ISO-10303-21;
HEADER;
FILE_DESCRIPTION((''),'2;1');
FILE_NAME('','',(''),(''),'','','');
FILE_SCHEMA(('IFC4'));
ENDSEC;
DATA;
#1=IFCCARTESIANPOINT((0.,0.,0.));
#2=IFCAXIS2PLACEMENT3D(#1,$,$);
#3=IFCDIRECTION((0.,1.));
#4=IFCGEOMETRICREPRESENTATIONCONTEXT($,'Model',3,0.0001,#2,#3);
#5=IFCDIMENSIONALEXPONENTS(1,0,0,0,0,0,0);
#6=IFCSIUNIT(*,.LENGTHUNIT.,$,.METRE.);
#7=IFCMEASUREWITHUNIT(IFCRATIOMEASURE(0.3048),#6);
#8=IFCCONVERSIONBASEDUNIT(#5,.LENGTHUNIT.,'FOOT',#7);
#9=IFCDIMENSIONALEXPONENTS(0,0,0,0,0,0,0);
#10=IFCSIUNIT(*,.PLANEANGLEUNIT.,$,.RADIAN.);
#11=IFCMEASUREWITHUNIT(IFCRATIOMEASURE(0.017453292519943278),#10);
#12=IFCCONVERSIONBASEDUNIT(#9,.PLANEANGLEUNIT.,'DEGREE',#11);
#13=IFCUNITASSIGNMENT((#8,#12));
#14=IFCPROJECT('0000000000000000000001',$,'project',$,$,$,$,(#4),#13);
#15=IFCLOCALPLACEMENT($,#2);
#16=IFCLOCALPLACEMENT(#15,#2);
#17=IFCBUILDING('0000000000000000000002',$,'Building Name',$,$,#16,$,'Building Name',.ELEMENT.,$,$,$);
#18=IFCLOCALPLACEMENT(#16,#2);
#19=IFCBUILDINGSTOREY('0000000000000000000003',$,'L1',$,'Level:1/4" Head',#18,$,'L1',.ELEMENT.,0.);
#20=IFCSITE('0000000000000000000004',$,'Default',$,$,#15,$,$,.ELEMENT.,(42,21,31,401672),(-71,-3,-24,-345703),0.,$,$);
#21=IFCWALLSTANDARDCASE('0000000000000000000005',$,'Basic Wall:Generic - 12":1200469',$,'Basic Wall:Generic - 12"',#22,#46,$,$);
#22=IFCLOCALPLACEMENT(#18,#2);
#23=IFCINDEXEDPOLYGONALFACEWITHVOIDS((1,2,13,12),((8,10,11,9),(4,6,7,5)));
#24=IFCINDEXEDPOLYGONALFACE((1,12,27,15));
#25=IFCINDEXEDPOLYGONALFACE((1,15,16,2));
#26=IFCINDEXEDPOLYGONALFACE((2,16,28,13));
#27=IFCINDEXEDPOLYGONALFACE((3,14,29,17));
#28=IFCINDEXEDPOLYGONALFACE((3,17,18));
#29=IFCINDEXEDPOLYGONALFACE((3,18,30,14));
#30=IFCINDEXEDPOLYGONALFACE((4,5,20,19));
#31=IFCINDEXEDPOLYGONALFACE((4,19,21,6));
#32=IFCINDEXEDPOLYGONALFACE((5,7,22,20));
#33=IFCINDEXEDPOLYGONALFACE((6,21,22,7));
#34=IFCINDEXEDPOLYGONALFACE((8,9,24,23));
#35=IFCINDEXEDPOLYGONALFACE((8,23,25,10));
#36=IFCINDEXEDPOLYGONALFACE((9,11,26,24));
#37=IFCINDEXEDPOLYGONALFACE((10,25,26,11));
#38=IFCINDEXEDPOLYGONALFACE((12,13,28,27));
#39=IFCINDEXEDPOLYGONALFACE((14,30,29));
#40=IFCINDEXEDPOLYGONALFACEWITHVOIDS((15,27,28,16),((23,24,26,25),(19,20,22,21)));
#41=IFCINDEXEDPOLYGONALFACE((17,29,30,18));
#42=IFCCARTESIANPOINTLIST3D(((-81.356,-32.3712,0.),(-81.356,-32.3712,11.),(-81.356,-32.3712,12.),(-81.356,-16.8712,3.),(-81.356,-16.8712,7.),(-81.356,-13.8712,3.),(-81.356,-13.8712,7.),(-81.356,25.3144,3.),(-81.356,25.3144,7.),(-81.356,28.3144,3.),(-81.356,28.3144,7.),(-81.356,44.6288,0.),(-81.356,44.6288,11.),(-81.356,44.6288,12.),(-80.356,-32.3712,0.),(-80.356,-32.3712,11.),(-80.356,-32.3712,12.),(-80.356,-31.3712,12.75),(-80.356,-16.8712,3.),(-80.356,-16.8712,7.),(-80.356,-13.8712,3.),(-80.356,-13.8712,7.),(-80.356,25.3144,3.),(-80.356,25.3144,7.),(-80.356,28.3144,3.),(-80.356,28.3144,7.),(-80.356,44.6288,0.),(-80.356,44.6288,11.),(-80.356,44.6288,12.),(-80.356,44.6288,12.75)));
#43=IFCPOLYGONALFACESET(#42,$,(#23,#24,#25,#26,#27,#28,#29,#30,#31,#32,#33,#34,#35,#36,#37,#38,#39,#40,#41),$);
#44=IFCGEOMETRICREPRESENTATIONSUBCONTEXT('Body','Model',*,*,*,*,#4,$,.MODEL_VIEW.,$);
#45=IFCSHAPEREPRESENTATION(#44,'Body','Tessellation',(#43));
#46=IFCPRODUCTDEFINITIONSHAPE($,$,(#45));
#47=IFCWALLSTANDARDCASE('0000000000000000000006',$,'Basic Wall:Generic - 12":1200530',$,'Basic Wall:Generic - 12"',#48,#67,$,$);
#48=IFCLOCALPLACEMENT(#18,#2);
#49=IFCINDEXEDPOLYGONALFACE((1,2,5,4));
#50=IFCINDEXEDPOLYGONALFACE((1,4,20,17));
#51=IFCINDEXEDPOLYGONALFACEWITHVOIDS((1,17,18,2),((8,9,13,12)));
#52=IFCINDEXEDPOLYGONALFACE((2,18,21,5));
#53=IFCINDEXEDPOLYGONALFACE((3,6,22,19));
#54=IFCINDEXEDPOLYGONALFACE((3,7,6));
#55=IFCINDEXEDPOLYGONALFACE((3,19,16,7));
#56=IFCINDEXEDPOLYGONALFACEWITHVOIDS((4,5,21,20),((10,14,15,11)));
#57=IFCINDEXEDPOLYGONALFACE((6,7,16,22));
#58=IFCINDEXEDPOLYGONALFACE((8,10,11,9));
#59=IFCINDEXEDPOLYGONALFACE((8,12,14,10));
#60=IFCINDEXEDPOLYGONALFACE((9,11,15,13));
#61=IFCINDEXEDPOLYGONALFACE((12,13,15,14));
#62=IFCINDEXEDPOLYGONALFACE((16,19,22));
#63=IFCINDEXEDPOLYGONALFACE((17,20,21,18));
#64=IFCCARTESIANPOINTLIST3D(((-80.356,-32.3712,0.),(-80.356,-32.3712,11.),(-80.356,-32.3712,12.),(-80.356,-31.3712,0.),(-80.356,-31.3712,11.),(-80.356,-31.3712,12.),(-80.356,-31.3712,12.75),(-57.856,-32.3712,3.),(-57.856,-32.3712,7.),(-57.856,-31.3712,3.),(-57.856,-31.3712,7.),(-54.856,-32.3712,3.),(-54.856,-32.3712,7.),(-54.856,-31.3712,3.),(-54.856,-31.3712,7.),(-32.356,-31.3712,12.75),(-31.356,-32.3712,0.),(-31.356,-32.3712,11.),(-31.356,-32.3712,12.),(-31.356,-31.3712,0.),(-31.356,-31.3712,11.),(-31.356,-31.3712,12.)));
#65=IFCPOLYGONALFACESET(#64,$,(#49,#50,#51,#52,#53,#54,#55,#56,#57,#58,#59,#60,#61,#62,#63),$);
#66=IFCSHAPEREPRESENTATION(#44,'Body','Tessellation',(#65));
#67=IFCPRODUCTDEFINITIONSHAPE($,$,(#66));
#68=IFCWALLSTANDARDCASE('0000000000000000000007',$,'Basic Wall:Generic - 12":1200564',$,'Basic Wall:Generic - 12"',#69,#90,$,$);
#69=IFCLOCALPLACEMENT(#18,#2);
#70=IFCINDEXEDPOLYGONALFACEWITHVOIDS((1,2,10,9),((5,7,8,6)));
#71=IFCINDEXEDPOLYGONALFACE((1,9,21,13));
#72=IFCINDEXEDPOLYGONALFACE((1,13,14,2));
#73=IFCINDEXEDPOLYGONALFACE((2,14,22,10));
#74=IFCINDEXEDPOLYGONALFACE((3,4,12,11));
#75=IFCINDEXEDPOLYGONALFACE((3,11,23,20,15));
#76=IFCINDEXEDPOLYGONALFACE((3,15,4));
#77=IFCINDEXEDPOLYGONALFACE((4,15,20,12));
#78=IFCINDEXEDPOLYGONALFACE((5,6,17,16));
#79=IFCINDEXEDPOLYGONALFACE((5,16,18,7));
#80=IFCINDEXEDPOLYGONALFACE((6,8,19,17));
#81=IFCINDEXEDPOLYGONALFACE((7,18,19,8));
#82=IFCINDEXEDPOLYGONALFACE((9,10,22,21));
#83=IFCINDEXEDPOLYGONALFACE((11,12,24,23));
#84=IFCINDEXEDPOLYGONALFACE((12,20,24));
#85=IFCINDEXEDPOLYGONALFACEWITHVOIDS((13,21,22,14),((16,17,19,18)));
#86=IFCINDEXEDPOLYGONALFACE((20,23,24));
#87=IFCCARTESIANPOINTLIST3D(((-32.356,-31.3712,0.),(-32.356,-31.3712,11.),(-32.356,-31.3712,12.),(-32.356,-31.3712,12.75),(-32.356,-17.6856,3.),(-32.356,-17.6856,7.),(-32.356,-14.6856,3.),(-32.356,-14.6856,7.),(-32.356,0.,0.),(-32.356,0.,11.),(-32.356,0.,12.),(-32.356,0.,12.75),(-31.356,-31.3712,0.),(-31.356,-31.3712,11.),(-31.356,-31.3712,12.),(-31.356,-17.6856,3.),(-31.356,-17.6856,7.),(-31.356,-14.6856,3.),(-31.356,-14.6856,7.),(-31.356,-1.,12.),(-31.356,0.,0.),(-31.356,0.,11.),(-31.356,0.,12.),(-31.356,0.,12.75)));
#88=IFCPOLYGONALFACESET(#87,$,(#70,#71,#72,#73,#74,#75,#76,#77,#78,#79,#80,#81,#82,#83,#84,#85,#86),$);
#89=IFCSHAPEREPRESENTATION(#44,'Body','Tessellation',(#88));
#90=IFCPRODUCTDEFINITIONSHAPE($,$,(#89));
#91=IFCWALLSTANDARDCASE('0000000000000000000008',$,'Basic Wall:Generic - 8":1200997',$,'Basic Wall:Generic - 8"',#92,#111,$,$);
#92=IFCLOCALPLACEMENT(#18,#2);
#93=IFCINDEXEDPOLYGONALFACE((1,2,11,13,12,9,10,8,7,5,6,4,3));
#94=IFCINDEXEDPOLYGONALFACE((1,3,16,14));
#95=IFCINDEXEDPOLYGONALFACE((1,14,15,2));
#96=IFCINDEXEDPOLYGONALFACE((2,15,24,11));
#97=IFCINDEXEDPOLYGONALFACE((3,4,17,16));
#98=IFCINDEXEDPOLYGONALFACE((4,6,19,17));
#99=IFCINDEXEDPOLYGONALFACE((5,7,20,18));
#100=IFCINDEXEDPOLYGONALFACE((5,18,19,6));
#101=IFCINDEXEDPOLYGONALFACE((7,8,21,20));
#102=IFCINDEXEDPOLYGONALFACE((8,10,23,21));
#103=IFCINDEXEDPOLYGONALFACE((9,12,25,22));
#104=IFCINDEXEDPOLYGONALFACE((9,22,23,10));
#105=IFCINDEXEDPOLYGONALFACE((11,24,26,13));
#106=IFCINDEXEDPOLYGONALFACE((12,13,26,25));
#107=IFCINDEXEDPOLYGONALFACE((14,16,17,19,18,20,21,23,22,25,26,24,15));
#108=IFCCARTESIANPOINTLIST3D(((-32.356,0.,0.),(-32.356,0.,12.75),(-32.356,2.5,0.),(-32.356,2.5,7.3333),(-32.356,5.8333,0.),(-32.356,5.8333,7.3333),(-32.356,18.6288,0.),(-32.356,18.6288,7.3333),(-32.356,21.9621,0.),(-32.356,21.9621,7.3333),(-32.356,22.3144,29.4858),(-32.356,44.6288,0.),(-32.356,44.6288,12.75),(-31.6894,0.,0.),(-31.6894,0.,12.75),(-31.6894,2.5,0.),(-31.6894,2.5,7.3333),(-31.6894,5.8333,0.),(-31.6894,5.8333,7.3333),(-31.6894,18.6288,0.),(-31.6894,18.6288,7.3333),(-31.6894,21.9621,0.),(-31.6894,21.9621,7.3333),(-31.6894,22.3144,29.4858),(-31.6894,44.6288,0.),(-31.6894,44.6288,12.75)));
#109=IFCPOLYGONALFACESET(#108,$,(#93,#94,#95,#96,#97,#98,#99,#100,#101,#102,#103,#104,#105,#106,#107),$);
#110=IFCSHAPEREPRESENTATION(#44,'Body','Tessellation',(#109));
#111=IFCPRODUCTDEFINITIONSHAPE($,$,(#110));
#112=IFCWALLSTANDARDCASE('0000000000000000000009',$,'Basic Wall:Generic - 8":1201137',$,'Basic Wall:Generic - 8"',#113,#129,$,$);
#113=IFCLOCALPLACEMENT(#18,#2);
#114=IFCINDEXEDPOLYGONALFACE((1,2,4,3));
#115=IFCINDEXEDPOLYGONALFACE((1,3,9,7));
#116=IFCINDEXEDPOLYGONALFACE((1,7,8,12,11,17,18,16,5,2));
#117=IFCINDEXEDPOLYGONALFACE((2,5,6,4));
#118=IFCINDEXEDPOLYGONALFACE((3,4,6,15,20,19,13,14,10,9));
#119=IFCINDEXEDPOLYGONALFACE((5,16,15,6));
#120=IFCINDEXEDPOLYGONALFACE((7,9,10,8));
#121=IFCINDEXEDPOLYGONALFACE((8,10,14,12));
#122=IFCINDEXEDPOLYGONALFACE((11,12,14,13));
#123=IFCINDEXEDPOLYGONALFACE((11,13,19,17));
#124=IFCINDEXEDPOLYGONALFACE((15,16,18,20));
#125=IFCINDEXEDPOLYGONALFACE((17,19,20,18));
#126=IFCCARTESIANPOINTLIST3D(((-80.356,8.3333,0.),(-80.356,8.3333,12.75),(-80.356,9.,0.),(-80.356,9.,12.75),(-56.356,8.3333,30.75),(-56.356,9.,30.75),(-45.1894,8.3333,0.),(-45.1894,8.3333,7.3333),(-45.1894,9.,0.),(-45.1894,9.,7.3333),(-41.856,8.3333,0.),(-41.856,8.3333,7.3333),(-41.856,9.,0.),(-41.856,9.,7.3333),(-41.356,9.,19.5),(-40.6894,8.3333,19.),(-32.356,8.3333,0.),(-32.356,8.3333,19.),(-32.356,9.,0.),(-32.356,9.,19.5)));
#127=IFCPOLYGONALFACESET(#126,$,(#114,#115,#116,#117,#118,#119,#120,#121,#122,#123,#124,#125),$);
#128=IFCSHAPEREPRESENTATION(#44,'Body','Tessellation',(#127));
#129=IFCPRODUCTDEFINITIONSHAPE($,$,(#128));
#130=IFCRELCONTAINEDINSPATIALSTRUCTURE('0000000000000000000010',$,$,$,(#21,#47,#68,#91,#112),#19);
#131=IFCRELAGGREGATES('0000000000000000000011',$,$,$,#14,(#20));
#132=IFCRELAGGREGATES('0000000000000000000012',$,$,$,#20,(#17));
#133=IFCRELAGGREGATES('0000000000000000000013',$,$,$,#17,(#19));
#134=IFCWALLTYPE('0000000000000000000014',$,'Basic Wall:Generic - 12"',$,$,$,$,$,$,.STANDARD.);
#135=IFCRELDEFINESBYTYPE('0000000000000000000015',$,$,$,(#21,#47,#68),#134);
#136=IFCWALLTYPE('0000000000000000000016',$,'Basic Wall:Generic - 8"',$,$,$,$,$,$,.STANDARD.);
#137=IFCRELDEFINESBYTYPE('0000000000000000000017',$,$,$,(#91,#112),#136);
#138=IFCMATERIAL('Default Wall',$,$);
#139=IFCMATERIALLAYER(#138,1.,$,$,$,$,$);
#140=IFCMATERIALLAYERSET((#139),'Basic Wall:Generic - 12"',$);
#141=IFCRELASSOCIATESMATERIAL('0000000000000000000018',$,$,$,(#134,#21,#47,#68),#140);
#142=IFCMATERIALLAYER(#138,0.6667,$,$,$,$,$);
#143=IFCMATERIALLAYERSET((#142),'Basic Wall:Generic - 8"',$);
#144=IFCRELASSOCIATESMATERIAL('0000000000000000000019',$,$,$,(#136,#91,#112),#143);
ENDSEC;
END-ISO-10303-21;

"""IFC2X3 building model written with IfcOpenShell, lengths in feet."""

from ifc_helpers import new_model, entity, si_unit, converted_unit, direction, frame, frame_2d, origin, place, context, subcontext, project, spatial, polyline, rectangle, extrude, clip, bounded_halfspace, material, layer, layer_set, layer_usage, type_object, element, save


model = new_model("IFC2X3")

# Units and contexts
model_context = context("Model", 3, precision=0.0001, world=origin(), true_north=direction((0.0, 1.0)))
body_context = subcontext(model_context, "Body", "Model", "MODEL_VIEW")
ifc_project = project(units=[converted_unit("LENGTHUNIT", "FOOT", entity("IfcRatioMeasure", 0.3048), si_unit("LENGTHUNIT", "METRE"), dimensions=[1, 0, 0, 0, 0, 0, 0]), converted_unit("PLANEANGLEUNIT", "DEGREE", entity("IfcRatioMeasure", 0.017453292519943278), si_unit("PLANEANGLEUNIT", "RADIAN"), dimensions=[0, 0, 0, 0, 0, 0, 0])], contexts=[model_context])

# Site, building, storey
site_placement = place(None, origin())
site = spatial("IfcSite", under=ifc_project, at=site_placement, Name="Default", CompositionType="ELEMENT", RefLatitude=(42, 21, 31, 401672), RefLongitude=(-71, -3, -24, -345703), RefElevation=0.0)
building_placement = place(site_placement, origin())
building = spatial("IfcBuilding", under=site, at=building_placement, Name="Building Name", LongName="Building Name", CompositionType="ELEMENT")
storey_placement = place(building_placement, origin())
storey = spatial("IfcBuildingStorey", under=building, at=storey_placement, Name="L1", ObjectType="Level:1/4\" Head", LongName="L1", CompositionType="ELEMENT", Elevation=0.0)

# Walls, openings
ifc_material_1 = material(Name="Default Wall")
ifc_layer_1 = layer(ifc_material_1, 1.0)
ifc_layer_set_1 = layer_set([ifc_layer_1], Name="Basic Wall:Generic - 12\"")
ifc_layer_usage_1 = layer_usage(ifc_layer_set_1, "AXIS2", "NEGATIVE", 0.5)
wall_type_1 = type_object("IfcWallType", Name="Basic Wall:Generic - 12\"", PredefinedType="STANDARD", material=ifc_layer_set_1)
wall_1_placement = place(storey_placement, frame((-80.856, 44.6288, 0.0), z_axis=(0.0, 0.0, 1.0), x_axis=(0.0, -1.0, 0.0)))
wall_1 = element("IfcWallStandardCase", 1, at=wall_1_placement, inside=storey, type_object=wall_type_1, material=ifc_layer_usage_1, Name="Basic Wall:Generic - 12\":1200469", ObjectType="Basic Wall:Generic - 12\"", context=body_context, shape_type="Clipping", body=[
    clip(clip(extrude(rectangle(XDim=77.0, YDim=1.0, at=frame_2d((38.5, 0.0), x_axis=(-1.0, 0.0))), origin(), (0.0, 0.0, 1.0), 12.75), bounded_halfspace(frame((0.0, 0.5, 12.75), z_axis=(0.0, -0.6, 0.8), x_axis=(1.0, 0.0, 0.0)), False, frame((0.0, 0.5, 12.75)), polyline([(0.0, 0.0), (0.0, -1.0), (77.0, -1.0), (76.0, 0.0), (36.2955, 0.0), (35.6288, 0.0), (0.0, 0.0)]))), bounded_halfspace(frame((77.0, 0.5, 12.0), z_axis=(0.6, 0.0, 0.8), x_axis=(0.0, 1.0, 0.0)), False, frame((77.0, 0.5, 12.0)), polyline([(0.0, 0.0), (-1.0, 0.0), (0.0, -1.0), (0.0, 0.0)]))),
])
opening_1_placement = place(storey_placement, frame((-80.856, 44.6288, 0.0), z_axis=(0.0, 0.0, 1.0), x_axis=(0.0, -1.0, 0.0)))
element("IfcOpeningElement", 2, at=opening_1_placement, cuts=wall_1, ObjectType="Opening", context=body_context, shape_type="SweptSolid", body=[
    extrude(rectangle(XDim=77.0, YDim=1.0, at=frame_2d((-7.5, -0.1), x_axis=(1.0, 0.0))), frame((46.0, 0.1, 11.0)), (0.0, 0.0, 1.0), 1.0),
])
opening_2_placement = place(wall_1_placement, frame((19.3144, 0.5, 3.0)))
element("IfcOpeningElement", 3, at=opening_2_placement, cuts=wall_1, ObjectType="Opening", context=body_context, shape_type="SweptSolid", body=[
    extrude(rectangle(XDim=4.0, YDim=3.0, at=frame_2d((2.0, 1.5), x_axis=(-1.0, 0.0))), frame((0.0, 0.0, 0.0), z_axis=(0.0, -1.0, 0.0), x_axis=(0.0, 0.0, 1.0)), (0.0, 0.0, 1.0), 1.0),
])
opening_3_placement = place(wall_1_placement, frame((61.5, 0.5, 3.0)))
element("IfcOpeningElement", 4, at=opening_3_placement, cuts=wall_1, ObjectType="Opening", context=body_context, shape_type="SweptSolid", body=[
    extrude(rectangle(XDim=4.0, YDim=3.0, at=frame_2d((2.0, 1.5), x_axis=(-1.0, 0.0))), frame((0.0, 0.0, 0.0), z_axis=(0.0, -1.0, 0.0), x_axis=(0.0, 0.0, 1.0)), (0.0, 0.0, 1.0), 1.0),
])
wall_2_placement = place(storey_placement, frame((-80.356, -31.8712, 0.0)))
wall_2 = element("IfcWallStandardCase", 5, at=wall_2_placement, inside=storey, type_object=wall_type_1, material=ifc_layer_usage_1, Name="Basic Wall:Generic - 12\":1200530", ObjectType="Basic Wall:Generic - 12\"", context=body_context, shape_type="Clipping", body=[
    clip(clip(extrude(rectangle(XDim=49.0, YDim=1.0, at=frame_2d((24.5, 0.0), x_axis=(-1.0, 0.0))), origin(), (0.0, 0.0, 1.0), 12.75), bounded_halfspace(frame((0.0, 0.5, 12.75), z_axis=(0.0, -0.6, 0.8), x_axis=(1.0, 0.0, 0.0)), False, frame((0.0, 0.5, 12.75)), polyline([(0.0, 0.0), (0.0, -1.0), (49.0, -1.0), (48.0, 0.0), (0.0, 0.0)]))), bounded_halfspace(frame((49.0, 0.5, 12.0), z_axis=(0.6, 0.0, 0.8), x_axis=(0.0, 1.0, 0.0)), False, frame((49.0, 0.5, 12.0)), polyline([(0.0, 0.0), (-1.0, 0.0), (0.0, -1.0), (0.0, 0.0)]))),
])
opening_4_placement = place(storey_placement, frame((-80.356, -31.8712, 0.0)))
element("IfcOpeningElement", 6, at=opening_4_placement, cuts=wall_2, ObjectType="Opening", context=body_context, shape_type="SweptSolid", body=[
    extrude(rectangle(XDim=49.0, YDim=1.0, at=frame_2d((-4.7, -0.1), x_axis=(1.0, 0.0))), frame((29.2, 0.1, 11.0)), (0.0, 0.0, 1.0), 1.0),
])
opening_5_placement = place(wall_2_placement, frame((22.5, -0.5, 3.0)))
element("IfcOpeningElement", 7, at=opening_5_placement, cuts=wall_2, ObjectType="Opening", context=body_context, shape_type="SweptSolid", body=[
    extrude(rectangle(XDim=4.0, YDim=3.0, at=frame_2d((2.0, 1.5), x_axis=(-1.0, 0.0))), frame((0.0, 0.0, 0.0), z_axis=(0.0, 1.0, 0.0), x_axis=(0.0, 0.0, 1.0)), (0.0, 0.0, 1.0), 1.0),
])
wall_3_placement = place(storey_placement, frame((-31.856, -31.3712, 0.0), z_axis=(0.0, 0.0, 1.0), x_axis=(0.0, 1.0, 0.0)))
wall_3 = element("IfcWallStandardCase", 8, at=wall_3_placement, inside=storey, type_object=wall_type_1, material=ifc_layer_usage_1, Name="Basic Wall:Generic - 12\":1200564", ObjectType="Basic Wall:Generic - 12\"", context=body_context, shape_type="Clipping", body=[
    clip(clip(extrude(rectangle(XDim=31.3712, YDim=1.0, at=frame_2d((15.6856, 0.0), x_axis=(-1.0, 0.0))), origin(), (0.0, 0.0, 1.0), 12.75), bounded_halfspace(frame((31.3712, 0.5, 12.75), z_axis=(0.0, -0.6, 0.8), x_axis=(1.0, 0.0, 0.0)), False, frame((31.3712, 0.5, 12.75)), polyline([(0.0, 0.0), (-31.3712, 0.0), (-31.3712, -1.0), (-1.0, -1.0), (0.0, 0.0)]))), bounded_halfspace(frame((31.3712, -0.5, 12.75), z_axis=(-0.6, 0.0, 0.8), x_axis=(0.0, -1.0, 0.0)), False, frame((31.3712, -0.5, 12.75)), polyline([(0.0, 0.0), (0.0, 0.3333), (0.0, 1.0), (-1.0, 0.0), (0.0, 0.0)]))),
])
opening_6_placement = place(storey_placement, frame((-31.856, -31.3712, 0.0), z_axis=(0.0, 0.0, 1.0), x_axis=(0.0, 1.0, 0.0)))
element("IfcOpeningElement", 9, at=opening_6_placement, cuts=wall_3, ObjectType="Opening", context=body_context, shape_type="SweptSolid", body=[
    extrude(rectangle(XDim=31.3712, YDim=1.0, at=frame_2d((-2.9371, 0.1), x_axis=(1.0, 0.0))), frame((18.6227, -0.1, 11.0)), (0.0, 0.0, 1.0), 1.0),
])
opening_7_placement = place(wall_3_placement, frame((16.6856, 0.5, 3.0)))
element("IfcOpeningElement", 10, at=opening_7_placement, cuts=wall_3, ObjectType="Opening", context=body_context, shape_type="SweptSolid", body=[
    extrude(rectangle(XDim=4.0, YDim=3.0, at=frame_2d((2.0, 1.5), x_axis=(-1.0, 0.0))), frame((0.0, 0.0, 0.0), z_axis=(0.0, -1.0, 0.0), x_axis=(0.0, 0.0, 1.0)), (0.0, 0.0, 1.0), 1.0),
])
ifc_layer_2 = layer(ifc_material_1, 0.6667)
ifc_layer_set_2 = layer_set([ifc_layer_2], Name="Basic Wall:Generic - 8\"")
ifc_layer_usage_2 = layer_usage(ifc_layer_set_2, "AXIS2", "NEGATIVE", 0.3333)
wall_type_2 = type_object("IfcWallType", Name="Basic Wall:Generic - 8\"", PredefinedType="STANDARD", material=ifc_layer_set_2)
wall_4_placement = place(storey_placement, frame((-32.0227, 0.0, 0.0), z_axis=(0.0, 0.0, 1.0), x_axis=(0.0, 1.0, 0.0)))
wall_4 = element("IfcWallStandardCase", 11, at=wall_4_placement, inside=storey, type_object=wall_type_2, material=ifc_layer_usage_2, Name="Basic Wall:Generic - 8\":1200997", ObjectType="Basic Wall:Generic - 8\"", context=body_context, shape_type="Clipping", body=[
    clip(clip(extrude(rectangle(XDim=44.6288, YDim=0.6667, at=frame_2d((22.3144, 0.0), x_axis=(-1.0, 0.0))), origin(), (0.0, 0.0, 1.0), 29.4858), bounded_halfspace(frame((0.0, 0.3333, 12.75), z_axis=(-0.6, 0.0, 0.8), x_axis=(0.0, -1.0, 0.0)), False, frame((0.0, 0.3333, 12.75)), polyline([(0.0, 0.0), (0.0, -0.6667), (22.3144, -0.6667), (22.3144, 0.0), (9.0, 0.0), (8.3333, 0.0), (0.0, 0.0)]))), bounded_halfspace(frame((44.6288, -0.3333, 12.75), z_axis=(0.6, 0.0, 0.8), x_axis=(0.0, 1.0, 0.0)), False, frame((44.6288, -0.3333, 12.75)), polyline([(0.0, 0.0), (0.0, 0.6667), (-22.3144, 0.6667), (-22.3144, 0.0), (-17.6667, 0.0), (-17.0, 0.0), (0.0, 0.0)]))),
])
opening_8_placement = place(wall_4_placement, frame((18.6288, -0.3333, 0.0)))
element("IfcOpeningElement", 12, at=opening_8_placement, cuts=wall_4, ObjectType="Opening", context=body_context, shape_type="SweptSolid", body=[
    extrude(rectangle(XDim=7.3333, YDim=3.3333, at=frame_2d((3.6667, 1.6667), x_axis=(1.0, 0.0))), frame((0.0, 0.0, 0.0), z_axis=(0.0, 1.0, 0.0), x_axis=(0.0, 0.0, 1.0)), (0.0, 0.0, 1.0), 0.6667),
])
opening_9_placement = place(wall_4_placement, frame((2.5, -0.3333, 0.0)))
element("IfcOpeningElement", 13, at=opening_9_placement, cuts=wall_4, ObjectType="Opening", context=body_context, shape_type="SweptSolid", body=[
    extrude(rectangle(XDim=7.3333, YDim=3.3333, at=frame_2d((3.6667, 1.6667), x_axis=(1.0, 0.0))), frame((0.0, 0.0, 0.0), z_axis=(0.0, 1.0, 0.0), x_axis=(0.0, 0.0, 1.0)), (0.0, 0.0, 1.0), 0.6667),
])

# Wall, opening
wall_5_placement = place(storey_placement, frame((-80.356, 8.6667, 0.0)))
wall_5 = element("IfcWallStandardCase", 14, at=wall_5_placement, inside=storey, type_object=wall_type_2, material=ifc_layer_usage_2, Name="Basic Wall:Generic - 8\":1201137", ObjectType="Basic Wall:Generic - 8\"", context=body_context, shape_type="Clipping", body=[
    clip(clip(clip(extrude(rectangle(XDim=48.0, YDim=0.6667, at=frame_2d((24.0, 0.0), x_axis=(-1.0, 0.0))), origin(), (0.0, 0.0, 1.0), 30.75), bounded_halfspace(frame((0.0, 0.3333, 12.75), z_axis=(-0.6, 0.0, 0.8), x_axis=(0.0, -1.0, 0.0)), False, frame((0.0, 0.3333, 12.75)), polyline([(0.0, 0.0), (0.0, -0.6667), (24.0, -0.6667), (24.0, 0.0), (0.0, 0.0)]))), bounded_halfspace(frame((24.0, -0.3333, 30.75), z_axis=(0.6, 0.0, 0.8), x_axis=(0.0, 1.0, 0.0)), False, frame((24.0, -0.3333, 30.75)), polyline([(0.0, 0.0), (15.6667, 0.0), (15.0, 0.6667), (0.0, 0.6667), (0.0, 0.0)]))), bounded_halfspace(frame((48.0, -0.3333, 19.0), z_axis=(0.0, -0.6, 0.8), x_axis=(1.0, 0.0, 0.0)), False, frame((48.0, -0.3333, 19.0)), polyline([(0.0, 0.0), (0.0, 0.6667), (-9.0, 0.6667), (-8.3333, 0.0), (0.0, 0.0)]))),
])
opening_10_placement = place(wall_5_placement, frame((38.5, 0.3333, 0.0)))
element("IfcOpeningElement", 15, at=opening_10_placement, cuts=wall_5, ObjectType="Opening", context=body_context, shape_type="SweptSolid", body=[
    extrude(rectangle(XDim=7.3333, YDim=3.3333, at=frame_2d((3.6667, 1.6667), x_axis=(1.0, 0.0))), frame((0.0, 0.0, 0.0), z_axis=(0.0, -1.0, 0.0), x_axis=(0.0, 0.0, 1.0)), (0.0, 0.0, 1.0), 0.6667),
])

save(model, "model.ifc")
